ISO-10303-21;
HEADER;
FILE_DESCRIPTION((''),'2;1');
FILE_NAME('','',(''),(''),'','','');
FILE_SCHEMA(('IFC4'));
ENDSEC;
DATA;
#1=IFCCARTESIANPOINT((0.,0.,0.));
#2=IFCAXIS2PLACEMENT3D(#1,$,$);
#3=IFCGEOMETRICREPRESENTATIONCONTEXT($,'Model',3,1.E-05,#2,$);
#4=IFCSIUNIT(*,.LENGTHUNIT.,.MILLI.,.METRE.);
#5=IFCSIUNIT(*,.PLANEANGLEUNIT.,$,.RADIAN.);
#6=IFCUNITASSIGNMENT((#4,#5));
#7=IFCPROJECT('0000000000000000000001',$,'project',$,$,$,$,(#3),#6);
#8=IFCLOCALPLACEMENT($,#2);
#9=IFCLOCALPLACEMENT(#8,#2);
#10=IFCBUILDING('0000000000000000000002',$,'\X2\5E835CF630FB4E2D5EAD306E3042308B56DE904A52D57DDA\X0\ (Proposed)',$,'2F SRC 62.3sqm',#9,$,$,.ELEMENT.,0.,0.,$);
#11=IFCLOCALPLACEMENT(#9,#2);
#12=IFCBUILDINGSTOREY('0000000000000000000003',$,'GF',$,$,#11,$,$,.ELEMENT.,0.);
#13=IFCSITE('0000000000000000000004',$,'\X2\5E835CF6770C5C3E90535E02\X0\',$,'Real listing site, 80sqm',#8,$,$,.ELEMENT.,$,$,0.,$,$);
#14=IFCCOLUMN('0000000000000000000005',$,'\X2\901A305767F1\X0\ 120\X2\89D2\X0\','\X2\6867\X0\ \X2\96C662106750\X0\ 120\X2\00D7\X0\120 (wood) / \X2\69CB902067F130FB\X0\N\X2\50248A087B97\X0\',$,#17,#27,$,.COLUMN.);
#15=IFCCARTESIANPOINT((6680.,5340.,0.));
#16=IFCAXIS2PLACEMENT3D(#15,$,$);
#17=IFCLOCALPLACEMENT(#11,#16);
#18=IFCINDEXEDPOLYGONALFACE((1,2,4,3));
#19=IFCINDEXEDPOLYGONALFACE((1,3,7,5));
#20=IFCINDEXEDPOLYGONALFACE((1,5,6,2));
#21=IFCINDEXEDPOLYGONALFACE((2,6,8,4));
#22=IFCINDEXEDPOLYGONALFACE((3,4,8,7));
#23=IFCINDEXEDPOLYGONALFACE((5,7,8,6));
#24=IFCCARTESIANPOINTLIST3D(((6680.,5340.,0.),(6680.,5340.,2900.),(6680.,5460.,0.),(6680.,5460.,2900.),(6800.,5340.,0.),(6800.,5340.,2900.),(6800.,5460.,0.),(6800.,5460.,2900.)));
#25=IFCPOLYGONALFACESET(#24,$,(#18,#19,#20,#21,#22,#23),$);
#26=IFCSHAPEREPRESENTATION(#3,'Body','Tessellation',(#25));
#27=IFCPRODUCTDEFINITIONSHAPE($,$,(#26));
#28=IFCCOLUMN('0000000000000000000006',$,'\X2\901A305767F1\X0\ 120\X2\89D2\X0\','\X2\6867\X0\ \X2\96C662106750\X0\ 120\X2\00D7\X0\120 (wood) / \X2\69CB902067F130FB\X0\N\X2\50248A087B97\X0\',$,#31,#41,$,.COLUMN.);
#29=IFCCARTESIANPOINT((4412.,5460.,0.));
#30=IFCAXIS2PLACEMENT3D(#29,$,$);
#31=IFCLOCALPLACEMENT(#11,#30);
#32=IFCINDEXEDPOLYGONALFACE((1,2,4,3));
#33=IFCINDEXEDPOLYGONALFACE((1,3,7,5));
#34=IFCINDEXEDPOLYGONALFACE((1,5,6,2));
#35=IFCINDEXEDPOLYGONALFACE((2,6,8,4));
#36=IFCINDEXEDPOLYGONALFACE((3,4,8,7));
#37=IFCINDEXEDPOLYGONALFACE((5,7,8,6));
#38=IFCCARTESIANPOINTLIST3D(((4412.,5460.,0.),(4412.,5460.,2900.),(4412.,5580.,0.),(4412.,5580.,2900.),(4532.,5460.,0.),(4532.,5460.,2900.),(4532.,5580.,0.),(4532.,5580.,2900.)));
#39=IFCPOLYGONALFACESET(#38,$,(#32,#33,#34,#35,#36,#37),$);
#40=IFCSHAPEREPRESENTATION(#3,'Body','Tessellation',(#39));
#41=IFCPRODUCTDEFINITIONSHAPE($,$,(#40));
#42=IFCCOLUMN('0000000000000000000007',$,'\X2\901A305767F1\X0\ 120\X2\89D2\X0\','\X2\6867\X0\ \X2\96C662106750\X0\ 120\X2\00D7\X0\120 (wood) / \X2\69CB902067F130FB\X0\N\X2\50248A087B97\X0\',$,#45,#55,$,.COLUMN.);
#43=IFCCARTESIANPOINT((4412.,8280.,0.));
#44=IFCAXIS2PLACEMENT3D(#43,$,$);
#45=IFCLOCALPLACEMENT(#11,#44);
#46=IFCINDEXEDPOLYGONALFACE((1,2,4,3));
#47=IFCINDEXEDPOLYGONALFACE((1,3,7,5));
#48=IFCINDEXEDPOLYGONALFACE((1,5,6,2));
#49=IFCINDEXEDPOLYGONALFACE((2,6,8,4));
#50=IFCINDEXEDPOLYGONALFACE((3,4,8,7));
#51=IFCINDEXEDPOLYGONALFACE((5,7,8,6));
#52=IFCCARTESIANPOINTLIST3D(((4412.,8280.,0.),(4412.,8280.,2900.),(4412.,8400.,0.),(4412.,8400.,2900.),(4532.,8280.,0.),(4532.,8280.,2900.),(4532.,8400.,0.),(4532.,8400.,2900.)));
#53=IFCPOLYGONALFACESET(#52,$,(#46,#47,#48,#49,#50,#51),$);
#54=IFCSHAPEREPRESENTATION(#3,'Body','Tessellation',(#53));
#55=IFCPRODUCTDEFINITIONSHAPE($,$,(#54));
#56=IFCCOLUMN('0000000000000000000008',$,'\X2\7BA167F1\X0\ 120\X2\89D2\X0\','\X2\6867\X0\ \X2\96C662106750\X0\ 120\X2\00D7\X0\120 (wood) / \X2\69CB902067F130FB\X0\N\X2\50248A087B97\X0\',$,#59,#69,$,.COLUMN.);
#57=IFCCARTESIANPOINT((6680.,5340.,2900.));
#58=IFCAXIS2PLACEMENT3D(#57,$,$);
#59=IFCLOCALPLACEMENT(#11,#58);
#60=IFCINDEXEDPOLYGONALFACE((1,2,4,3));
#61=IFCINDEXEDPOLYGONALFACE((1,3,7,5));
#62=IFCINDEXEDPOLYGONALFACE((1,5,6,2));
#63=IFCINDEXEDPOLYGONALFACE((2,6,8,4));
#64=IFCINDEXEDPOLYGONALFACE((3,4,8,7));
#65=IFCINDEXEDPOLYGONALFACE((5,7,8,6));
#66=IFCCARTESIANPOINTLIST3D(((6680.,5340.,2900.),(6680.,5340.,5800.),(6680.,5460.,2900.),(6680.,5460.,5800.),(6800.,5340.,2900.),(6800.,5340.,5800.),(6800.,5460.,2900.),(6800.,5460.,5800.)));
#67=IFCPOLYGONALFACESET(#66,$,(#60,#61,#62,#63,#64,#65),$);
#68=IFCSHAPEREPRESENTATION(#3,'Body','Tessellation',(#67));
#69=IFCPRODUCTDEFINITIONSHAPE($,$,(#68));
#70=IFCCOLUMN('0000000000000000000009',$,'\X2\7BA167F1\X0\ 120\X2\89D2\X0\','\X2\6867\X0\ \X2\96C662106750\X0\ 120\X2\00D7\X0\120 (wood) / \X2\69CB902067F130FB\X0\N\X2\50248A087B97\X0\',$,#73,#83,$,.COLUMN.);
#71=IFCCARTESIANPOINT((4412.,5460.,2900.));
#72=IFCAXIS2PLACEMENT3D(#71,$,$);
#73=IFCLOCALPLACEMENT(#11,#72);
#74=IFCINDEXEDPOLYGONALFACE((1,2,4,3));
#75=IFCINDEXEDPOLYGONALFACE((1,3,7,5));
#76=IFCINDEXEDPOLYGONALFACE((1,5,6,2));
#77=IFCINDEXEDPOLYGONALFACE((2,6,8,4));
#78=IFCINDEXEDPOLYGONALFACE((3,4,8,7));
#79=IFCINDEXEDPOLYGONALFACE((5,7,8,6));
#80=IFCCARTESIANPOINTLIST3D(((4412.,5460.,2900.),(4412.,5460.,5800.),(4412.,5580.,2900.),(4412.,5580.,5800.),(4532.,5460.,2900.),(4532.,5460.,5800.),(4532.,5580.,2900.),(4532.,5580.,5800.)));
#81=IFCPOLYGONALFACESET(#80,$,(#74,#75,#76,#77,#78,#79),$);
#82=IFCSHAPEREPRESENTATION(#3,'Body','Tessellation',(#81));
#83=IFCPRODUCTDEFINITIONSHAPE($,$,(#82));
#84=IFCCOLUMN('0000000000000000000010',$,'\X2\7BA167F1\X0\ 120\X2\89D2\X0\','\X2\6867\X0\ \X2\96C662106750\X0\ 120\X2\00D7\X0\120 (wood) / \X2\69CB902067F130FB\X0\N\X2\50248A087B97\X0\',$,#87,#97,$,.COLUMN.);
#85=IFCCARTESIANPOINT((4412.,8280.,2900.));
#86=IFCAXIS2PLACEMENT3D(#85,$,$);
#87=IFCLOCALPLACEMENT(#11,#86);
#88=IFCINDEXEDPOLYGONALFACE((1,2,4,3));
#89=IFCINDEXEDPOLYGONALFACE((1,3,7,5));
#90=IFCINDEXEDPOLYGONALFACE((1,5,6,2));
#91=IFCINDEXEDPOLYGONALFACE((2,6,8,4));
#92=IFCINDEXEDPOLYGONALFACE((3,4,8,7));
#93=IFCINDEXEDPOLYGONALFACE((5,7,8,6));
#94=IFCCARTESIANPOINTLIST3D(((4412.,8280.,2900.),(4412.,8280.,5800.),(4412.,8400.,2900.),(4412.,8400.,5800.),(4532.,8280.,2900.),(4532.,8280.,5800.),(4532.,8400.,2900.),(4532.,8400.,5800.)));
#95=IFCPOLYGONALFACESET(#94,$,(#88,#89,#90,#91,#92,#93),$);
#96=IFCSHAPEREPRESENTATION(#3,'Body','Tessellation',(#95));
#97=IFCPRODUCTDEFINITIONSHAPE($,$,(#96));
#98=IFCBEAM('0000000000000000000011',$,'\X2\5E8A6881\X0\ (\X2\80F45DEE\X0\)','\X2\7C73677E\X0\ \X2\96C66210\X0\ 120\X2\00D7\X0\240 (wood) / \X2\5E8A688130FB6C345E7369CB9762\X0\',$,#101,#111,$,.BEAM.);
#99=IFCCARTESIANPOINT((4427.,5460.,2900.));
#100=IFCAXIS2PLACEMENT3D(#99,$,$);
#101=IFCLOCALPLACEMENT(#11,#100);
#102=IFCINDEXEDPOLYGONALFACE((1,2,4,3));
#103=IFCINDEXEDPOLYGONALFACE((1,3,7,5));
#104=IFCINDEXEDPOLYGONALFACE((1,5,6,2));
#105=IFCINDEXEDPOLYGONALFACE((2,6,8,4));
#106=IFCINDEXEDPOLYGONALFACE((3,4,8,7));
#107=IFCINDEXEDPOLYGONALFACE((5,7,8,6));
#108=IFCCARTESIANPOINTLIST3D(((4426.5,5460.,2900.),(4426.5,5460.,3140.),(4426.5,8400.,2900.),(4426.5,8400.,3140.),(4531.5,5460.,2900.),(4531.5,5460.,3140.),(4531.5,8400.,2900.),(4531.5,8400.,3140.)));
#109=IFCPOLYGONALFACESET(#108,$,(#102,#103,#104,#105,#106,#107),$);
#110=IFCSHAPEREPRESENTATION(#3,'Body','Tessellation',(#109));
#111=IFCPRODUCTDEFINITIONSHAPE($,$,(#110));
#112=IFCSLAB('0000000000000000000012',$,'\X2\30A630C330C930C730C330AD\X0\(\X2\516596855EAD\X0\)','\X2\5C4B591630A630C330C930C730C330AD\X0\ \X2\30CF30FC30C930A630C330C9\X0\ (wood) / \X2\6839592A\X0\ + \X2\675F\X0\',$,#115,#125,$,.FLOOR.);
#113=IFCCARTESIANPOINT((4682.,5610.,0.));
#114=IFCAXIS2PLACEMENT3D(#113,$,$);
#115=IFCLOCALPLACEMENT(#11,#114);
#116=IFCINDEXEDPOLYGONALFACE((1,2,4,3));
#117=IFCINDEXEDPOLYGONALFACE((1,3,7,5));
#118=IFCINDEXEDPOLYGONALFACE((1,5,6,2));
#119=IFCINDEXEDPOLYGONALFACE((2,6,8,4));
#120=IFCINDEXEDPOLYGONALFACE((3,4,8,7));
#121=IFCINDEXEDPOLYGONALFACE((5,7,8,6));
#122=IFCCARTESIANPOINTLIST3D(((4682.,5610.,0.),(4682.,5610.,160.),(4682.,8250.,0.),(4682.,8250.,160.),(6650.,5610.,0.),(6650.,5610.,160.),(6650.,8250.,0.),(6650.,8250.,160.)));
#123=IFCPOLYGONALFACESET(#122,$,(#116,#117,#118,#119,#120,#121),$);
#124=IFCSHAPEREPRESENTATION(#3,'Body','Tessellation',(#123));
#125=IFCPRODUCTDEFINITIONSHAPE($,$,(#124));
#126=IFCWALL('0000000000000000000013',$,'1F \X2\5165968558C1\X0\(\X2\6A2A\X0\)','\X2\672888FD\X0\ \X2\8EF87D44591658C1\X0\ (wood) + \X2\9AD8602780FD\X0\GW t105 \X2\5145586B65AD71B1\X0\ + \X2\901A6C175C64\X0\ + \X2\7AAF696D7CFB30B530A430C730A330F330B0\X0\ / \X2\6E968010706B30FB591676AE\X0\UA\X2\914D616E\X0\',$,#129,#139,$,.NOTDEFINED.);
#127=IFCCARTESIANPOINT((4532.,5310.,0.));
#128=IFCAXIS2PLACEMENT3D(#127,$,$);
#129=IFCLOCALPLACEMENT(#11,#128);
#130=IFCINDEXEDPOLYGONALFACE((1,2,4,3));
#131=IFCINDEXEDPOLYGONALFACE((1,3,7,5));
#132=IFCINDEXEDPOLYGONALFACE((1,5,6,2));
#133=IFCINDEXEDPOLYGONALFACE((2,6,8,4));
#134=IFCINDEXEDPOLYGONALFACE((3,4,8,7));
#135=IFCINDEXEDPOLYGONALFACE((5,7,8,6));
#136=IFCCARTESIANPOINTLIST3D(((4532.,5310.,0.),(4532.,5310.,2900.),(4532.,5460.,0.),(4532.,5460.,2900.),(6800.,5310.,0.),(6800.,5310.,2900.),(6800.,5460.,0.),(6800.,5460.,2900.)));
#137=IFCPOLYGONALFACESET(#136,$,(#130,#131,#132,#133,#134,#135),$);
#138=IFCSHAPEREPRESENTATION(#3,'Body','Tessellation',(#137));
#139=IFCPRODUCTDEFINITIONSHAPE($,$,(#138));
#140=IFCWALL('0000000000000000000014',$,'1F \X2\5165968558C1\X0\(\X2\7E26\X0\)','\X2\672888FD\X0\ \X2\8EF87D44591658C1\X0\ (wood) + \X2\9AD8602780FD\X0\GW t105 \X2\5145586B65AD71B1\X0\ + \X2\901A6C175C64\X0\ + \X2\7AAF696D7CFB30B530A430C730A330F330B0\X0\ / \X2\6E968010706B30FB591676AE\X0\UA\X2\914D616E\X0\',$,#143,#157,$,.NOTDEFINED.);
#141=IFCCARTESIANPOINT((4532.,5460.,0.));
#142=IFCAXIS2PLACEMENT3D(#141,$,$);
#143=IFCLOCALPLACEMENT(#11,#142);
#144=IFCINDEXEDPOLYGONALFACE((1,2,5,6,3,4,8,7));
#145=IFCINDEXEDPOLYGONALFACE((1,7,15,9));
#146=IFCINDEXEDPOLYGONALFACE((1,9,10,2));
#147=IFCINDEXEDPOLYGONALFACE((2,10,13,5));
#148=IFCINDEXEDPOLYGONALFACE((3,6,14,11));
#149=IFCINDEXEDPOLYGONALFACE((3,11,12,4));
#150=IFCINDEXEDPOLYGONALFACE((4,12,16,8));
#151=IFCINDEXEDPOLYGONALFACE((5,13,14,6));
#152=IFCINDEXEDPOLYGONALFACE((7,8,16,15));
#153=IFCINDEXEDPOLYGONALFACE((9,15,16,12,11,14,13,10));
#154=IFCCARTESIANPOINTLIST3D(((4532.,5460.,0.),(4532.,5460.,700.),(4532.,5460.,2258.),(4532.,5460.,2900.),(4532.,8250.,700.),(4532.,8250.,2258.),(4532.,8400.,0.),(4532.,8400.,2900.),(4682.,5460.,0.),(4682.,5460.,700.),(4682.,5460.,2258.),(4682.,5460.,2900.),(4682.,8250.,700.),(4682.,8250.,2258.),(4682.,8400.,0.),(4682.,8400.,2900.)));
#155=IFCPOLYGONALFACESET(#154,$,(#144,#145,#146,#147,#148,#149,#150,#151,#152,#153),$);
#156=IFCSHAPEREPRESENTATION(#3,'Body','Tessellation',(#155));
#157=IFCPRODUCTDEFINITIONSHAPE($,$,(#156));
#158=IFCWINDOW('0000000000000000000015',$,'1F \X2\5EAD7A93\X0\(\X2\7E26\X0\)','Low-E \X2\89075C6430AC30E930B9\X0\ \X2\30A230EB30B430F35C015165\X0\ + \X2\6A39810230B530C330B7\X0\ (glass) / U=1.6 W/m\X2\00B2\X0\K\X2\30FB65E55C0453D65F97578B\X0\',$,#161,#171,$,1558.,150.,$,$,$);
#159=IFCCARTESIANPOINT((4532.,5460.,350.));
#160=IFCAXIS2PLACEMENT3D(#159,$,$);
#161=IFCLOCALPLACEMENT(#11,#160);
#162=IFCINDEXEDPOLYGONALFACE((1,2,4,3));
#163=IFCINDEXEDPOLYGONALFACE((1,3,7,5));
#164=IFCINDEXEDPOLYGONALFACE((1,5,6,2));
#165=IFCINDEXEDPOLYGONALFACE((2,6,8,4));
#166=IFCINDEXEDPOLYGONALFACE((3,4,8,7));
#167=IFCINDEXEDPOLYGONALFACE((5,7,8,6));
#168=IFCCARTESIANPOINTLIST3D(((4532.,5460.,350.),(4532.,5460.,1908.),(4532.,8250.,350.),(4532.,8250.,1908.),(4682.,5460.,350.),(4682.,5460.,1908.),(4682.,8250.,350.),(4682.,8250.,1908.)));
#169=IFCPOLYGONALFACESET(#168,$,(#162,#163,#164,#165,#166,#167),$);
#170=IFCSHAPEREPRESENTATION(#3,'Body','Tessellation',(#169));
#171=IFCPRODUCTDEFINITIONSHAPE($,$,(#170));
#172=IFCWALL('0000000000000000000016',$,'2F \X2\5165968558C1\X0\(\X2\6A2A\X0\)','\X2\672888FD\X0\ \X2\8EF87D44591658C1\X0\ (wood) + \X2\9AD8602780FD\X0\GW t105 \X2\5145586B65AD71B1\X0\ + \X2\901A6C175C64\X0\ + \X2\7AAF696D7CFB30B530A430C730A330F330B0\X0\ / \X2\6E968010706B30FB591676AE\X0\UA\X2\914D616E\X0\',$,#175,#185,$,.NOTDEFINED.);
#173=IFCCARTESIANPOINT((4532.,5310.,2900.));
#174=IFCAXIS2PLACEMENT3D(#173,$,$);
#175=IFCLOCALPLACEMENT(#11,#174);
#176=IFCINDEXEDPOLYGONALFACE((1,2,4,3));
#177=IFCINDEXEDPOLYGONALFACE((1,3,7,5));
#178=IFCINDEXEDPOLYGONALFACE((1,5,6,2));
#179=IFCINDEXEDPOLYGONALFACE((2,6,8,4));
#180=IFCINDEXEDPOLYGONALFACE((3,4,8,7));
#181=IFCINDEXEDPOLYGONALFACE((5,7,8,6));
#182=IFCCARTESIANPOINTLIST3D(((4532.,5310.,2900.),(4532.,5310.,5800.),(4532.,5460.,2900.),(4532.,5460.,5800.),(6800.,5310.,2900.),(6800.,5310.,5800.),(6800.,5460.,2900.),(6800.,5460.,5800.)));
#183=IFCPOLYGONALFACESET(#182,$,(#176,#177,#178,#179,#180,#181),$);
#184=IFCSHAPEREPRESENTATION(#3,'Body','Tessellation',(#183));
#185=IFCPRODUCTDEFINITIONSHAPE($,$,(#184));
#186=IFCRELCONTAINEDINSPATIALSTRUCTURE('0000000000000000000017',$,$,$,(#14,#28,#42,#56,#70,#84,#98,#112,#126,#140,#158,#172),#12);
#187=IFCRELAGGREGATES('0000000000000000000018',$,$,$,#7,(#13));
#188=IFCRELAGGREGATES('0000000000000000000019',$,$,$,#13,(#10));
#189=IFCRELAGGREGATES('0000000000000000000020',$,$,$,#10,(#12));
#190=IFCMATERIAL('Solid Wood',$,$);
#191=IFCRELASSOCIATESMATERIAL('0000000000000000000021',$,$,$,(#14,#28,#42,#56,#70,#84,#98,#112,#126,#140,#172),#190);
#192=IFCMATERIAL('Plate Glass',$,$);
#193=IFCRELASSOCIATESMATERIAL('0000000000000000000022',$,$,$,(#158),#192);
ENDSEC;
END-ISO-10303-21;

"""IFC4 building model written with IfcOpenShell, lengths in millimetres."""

from ifc_helpers import new_model, si_unit, frame, frame_2d, origin, place, context, project, spatial, rectangle, extrude, material, element, fill, save


model = new_model("IFC4")

# Units and contexts
model_context = context("Model", 3, precision=1e-05, world=origin())
ifc_project = project(units=[si_unit("LENGTHUNIT", "METRE", prefix="MILLI"), si_unit("PLANEANGLEUNIT", "RADIAN")], contexts=[model_context])

# Site, building, storey
site_placement = place(None, origin())
site = spatial("IfcSite", under=ifc_project, at=site_placement, Name="広島県尾道市", ObjectType="Real listing site, 80sqm", CompositionType="ELEMENT", RefElevation=0.0)
building_placement = place(site_placement, origin())
building = spatial("IfcBuilding", under=site, at=building_placement, Name="広島・中庭のある回遊動線 (Proposed)", ObjectType="2F SRC 62.3sqm", CompositionType="ELEMENT", ElevationOfRefHeight=0.0, ElevationOfTerrain=0.0)
storey_placement = place(building_placement, origin())
storey = spatial("IfcBuildingStorey", under=building, at=storey_placement, Name="GF", CompositionType="ELEMENT", Elevation=0.0)

# Columns
ifc_material_1 = material(Name="Solid Wood")
column_1_placement = place(storey_placement, frame((6680.0, 5340.0, 0.0)))
element("IfcColumn", 1, at=column_1_placement, inside=storey, material=ifc_material_1, Name="通し柱 120角", Description="桧 集成材 120×120 (wood) / 構造柱・N値計算", PredefinedType="COLUMN", context=model_context, shape_type="SweptSolid", body=[
    extrude(rectangle(XDim=120.0, YDim=120.0, at=frame_2d((60.0, 60.0))), frame((6680.0, 5340.0, 0.0)), (0.0, 0.0, 1.0), 2900.0),
])
column_2_placement = place(storey_placement, frame((4412.0, 5460.0, 0.0)))
element("IfcColumn", 2, at=column_2_placement, inside=storey, material=ifc_material_1, Name="通し柱 120角", Description="桧 集成材 120×120 (wood) / 構造柱・N値計算", PredefinedType="COLUMN", context=model_context, shape_type="SweptSolid", body=[
    extrude(rectangle(XDim=120.0, YDim=120.0, at=frame_2d((60.0, 60.0))), frame((4412.0, 5460.0, 0.0)), (0.0, 0.0, 1.0), 2900.0),
])
column_3_placement = place(storey_placement, frame((4412.0, 8280.0, 0.0)))
element("IfcColumn", 3, at=column_3_placement, inside=storey, material=ifc_material_1, Name="通し柱 120角", Description="桧 集成材 120×120 (wood) / 構造柱・N値計算", PredefinedType="COLUMN", context=model_context, shape_type="SweptSolid", body=[
    extrude(rectangle(XDim=120.0, YDim=120.0, at=frame_2d((60.0, 60.0))), frame((4412.0, 8280.0, 0.0)), (0.0, 0.0, 1.0), 2900.0),
])
column_4_placement = place(storey_placement, frame((6680.0, 5340.0, 2900.0)))
element("IfcColumn", 4, at=column_4_placement, inside=storey, material=ifc_material_1, Name="管柱 120角", Description="桧 集成材 120×120 (wood) / 構造柱・N値計算", PredefinedType="COLUMN", context=model_context, shape_type="SweptSolid", body=[
    extrude(rectangle(XDim=120.0, YDim=120.0, at=frame_2d((60.0, 60.0))), frame((6680.0, 5340.0, 2900.0)), (0.0, 0.0, 1.0), 2900.0),
])
column_5_placement = place(storey_placement, frame((4412.0, 5460.0, 2900.0)))
element("IfcColumn", 5, at=column_5_placement, inside=storey, material=ifc_material_1, Name="管柱 120角", Description="桧 集成材 120×120 (wood) / 構造柱・N値計算", PredefinedType="COLUMN", context=model_context, shape_type="SweptSolid", body=[
    extrude(rectangle(XDim=120.0, YDim=120.0, at=frame_2d((60.0, 60.0))), frame((4412.0, 5460.0, 2900.0)), (0.0, 0.0, 1.0), 2900.0),
])
column_6_placement = place(storey_placement, frame((4412.0, 8280.0, 2900.0)))
element("IfcColumn", 6, at=column_6_placement, inside=storey, material=ifc_material_1, Name="管柱 120角", Description="桧 集成材 120×120 (wood) / 構造柱・N値計算", PredefinedType="COLUMN", context=model_context, shape_type="SweptSolid", body=[
    extrude(rectangle(XDim=120.0, YDim=120.0, at=frame_2d((60.0, 60.0))), frame((4412.0, 8280.0, 2900.0)), (0.0, 0.0, 1.0), 2900.0),
])

# Beam
beam_1_placement = place(storey_placement, frame((4427.0, 5460.0, 2900.0)))
element("IfcBeam", 7, at=beam_1_placement, inside=storey, material=ifc_material_1, Name="床梁 (胴差)", Description="米松 集成 120×240 (wood) / 床梁・水平構面", PredefinedType="BEAM", context=model_context, shape_type="SweptSolid", body=[
    extrude(rectangle(XDim=105.0, YDim=2940.0, at=frame_2d((52.0, 1470.0))), frame((4427.0, 5460.0, 2900.0)), (0.0, 0.0, 1.0), 240.0),
])

# Slab
slab_placement = place(storey_placement, frame((4682.0, 5610.0, 0.0)))
element("IfcSlab", 8, at=slab_placement, inside=storey, material=ifc_material_1, Name="ウッドデッキ(入隅庭)", Description="屋外ウッドデッキ ハードウッド (wood) / 根太 + 束", PredefinedType="FLOOR", context=model_context, shape_type="SweptSolid", body=[
    extrude(rectangle(XDim=1968.0, YDim=2640.0, at=frame_2d((984.0, 1320.0))), frame((4682.0, 5610.0, 0.0)), (0.0, 0.0, 1.0), 160.0),
])

# Wall
wall_1_placement = place(storey_placement, frame((4532.0, 5310.0, 0.0)))
element("IfcWall", 9, at=wall_1_placement, inside=storey, material=ifc_material_1, Name="1F 入隅壁(横)", Description="木製 軸組外壁 (wood) + 高性能GW t105 充填断熱 + 通気層 + 窯業系サイディング / 準耐火・外皮UA配慮", PredefinedType="NOTDEFINED", context=model_context, shape_type="SweptSolid", body=[
    extrude(rectangle(XDim=2268.0, YDim=150.0, at=frame_2d((1134.0, 75.0))), frame((4532.0, 5310.0, 0.0)), (0.0, 0.0, 1.0), 2900.0),
])

# Wall, opening, window
wall_2_placement = place(storey_placement, frame((4532.0, 5460.0, 0.0)))
wall_2 = element("IfcWall", 10, at=wall_2_placement, inside=storey, material=ifc_material_1, Name="1F 入隅壁(縦)", Description="木製 軸組外壁 (wood) + 高性能GW t105 充填断熱 + 通気層 + 窯業系サイディング / 準耐火・外皮UA配慮", PredefinedType="NOTDEFINED", context=model_context, shape_type="SweptSolid", body=[
    extrude(rectangle(XDim=150.0, YDim=2940.0, at=frame_2d((75.0, 1470.0))), frame((4532.0, 5460.0, 0.0)), (0.0, 0.0, 1.0), 2900.0),
])
opening_1_placement = place(storey_placement, frame((4532.0, 5460.0, 350.0)))
opening_1 = element("IfcOpeningElement", 11, at=opening_1_placement, cuts=wall_2, PredefinedType="NOTDEFINED", context=model_context, shape_type="SweptSolid", body=[
    extrude(rectangle(XDim=150.0, YDim=2790.0, at=frame_2d((75.0, 1395.0))), frame((4532.0, 5460.0, 350.0)), (0.0, 0.0, 1.0), 1558.0),
])
ifc_material_2 = material(Name="Plate Glass")
window_1_placement = place(storey_placement, frame((4532.0, 5460.0, 350.0)))
window_1 = element("IfcWindow", 12, at=window_1_placement, inside=storey, material=ifc_material_2, Name="1F 庭窓(縦)", Description="Low-E 複層ガラス アルゴン封入 + 樹脂サッシ (glass) / U=1.6 W/m²K・日射取得型", OverallHeight=1558.0, OverallWidth=150.0, context=model_context, shape_type="SweptSolid", body=[
    extrude(rectangle(XDim=150.0, YDim=2790.0, at=frame_2d((75.0, 1395.0))), frame((4532.0, 5460.0, 350.0)), (0.0, 0.0, 1.0), 1558.0),
])
fill(opening_1, window_1)

# Wall
wall_3_placement = place(storey_placement, frame((4532.0, 5310.0, 2900.0)))
element("IfcWall", 13, at=wall_3_placement, inside=storey, material=ifc_material_1, Name="2F 入隅壁(横)", Description="木製 軸組外壁 (wood) + 高性能GW t105 充填断熱 + 通気層 + 窯業系サイディング / 準耐火・外皮UA配慮", PredefinedType="NOTDEFINED", context=model_context, shape_type="SweptSolid", body=[
    extrude(rectangle(XDim=2268.0, YDim=150.0, at=frame_2d((1134.0, 75.0))), frame((4532.0, 5310.0, 2900.0)), (0.0, 0.0, 1.0), 2900.0),
])

save(model, "model.ifc")
